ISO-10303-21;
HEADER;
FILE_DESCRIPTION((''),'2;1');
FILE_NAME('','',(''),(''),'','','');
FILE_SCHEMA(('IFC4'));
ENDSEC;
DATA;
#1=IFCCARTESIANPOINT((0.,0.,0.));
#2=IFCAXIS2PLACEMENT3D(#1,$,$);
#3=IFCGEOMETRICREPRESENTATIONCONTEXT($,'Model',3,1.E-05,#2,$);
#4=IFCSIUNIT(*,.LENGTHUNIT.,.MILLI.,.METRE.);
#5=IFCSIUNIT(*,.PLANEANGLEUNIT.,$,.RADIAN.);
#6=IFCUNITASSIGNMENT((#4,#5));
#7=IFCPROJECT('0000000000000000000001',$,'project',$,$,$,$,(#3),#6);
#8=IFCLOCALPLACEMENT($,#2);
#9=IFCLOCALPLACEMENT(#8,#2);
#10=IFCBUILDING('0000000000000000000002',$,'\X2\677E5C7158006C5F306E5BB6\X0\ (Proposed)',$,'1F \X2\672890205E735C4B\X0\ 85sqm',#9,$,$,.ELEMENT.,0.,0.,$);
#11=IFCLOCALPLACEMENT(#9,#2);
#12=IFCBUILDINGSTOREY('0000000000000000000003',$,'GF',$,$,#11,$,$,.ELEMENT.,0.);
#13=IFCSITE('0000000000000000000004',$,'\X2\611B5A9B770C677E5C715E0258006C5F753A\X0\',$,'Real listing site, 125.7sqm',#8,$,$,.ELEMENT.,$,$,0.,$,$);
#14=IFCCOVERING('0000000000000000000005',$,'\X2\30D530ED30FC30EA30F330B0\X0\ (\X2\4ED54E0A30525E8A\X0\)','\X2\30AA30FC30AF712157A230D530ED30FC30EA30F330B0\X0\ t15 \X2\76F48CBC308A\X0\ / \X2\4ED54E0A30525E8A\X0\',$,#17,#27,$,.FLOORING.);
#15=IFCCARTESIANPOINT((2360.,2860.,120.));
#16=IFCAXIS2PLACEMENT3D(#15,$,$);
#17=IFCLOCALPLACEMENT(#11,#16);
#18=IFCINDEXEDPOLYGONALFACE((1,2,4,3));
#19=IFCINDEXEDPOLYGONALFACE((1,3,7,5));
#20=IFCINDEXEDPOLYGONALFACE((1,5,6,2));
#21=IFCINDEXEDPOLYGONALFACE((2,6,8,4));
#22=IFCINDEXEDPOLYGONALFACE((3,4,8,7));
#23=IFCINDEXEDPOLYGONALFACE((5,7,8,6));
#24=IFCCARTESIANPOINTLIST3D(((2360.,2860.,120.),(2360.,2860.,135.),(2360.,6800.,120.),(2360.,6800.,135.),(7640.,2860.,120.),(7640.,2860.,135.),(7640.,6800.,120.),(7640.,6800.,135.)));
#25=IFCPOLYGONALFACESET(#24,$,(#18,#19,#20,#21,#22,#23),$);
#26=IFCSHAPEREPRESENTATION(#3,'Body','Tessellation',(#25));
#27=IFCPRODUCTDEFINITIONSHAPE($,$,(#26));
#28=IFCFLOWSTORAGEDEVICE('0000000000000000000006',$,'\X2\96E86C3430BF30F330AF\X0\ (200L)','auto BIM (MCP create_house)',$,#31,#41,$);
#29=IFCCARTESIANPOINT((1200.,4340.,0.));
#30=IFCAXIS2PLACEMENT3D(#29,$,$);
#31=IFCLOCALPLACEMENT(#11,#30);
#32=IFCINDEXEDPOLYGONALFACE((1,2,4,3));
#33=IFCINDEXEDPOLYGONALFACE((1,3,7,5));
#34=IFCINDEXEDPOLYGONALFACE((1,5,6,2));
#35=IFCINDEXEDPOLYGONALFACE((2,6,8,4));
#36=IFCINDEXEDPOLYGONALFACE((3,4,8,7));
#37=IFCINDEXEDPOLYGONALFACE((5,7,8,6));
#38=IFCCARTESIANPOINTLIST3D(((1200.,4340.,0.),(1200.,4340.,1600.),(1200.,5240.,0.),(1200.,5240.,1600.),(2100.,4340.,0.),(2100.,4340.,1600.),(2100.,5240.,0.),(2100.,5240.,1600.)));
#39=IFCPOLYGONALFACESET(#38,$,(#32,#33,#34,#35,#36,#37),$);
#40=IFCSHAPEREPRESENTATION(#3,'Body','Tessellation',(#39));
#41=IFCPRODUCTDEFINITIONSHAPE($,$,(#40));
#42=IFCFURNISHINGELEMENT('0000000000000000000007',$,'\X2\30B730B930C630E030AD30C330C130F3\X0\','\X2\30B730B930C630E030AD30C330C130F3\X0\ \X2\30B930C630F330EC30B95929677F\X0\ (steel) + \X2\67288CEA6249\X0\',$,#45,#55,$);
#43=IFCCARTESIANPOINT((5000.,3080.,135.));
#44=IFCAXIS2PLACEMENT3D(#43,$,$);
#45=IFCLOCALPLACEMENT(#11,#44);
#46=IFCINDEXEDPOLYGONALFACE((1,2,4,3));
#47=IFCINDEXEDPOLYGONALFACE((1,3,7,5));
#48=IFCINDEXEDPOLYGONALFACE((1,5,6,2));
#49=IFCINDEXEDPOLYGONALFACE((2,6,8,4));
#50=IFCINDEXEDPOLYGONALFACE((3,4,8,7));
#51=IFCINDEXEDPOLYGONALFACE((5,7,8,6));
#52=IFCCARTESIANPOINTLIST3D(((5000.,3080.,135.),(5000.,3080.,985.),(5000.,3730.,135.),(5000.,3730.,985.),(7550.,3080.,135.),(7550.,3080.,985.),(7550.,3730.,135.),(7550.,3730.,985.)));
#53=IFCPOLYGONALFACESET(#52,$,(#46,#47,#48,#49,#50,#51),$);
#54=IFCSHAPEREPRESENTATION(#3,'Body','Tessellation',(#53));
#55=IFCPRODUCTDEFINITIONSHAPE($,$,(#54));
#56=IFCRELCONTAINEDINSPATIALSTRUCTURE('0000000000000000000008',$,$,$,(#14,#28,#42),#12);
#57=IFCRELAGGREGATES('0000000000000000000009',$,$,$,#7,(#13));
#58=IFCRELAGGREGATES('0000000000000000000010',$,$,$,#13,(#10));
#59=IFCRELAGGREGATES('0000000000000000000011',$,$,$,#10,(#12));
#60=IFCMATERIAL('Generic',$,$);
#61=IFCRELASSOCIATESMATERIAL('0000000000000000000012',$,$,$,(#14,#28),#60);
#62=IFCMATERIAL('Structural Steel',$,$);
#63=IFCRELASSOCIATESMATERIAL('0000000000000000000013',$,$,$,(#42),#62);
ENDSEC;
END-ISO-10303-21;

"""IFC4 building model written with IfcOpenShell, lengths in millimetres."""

from ifc_helpers import new_model, si_unit, frame, frame_2d, origin, place, context, project, spatial, rectangle, extrude, material, element, save


model = new_model("IFC4")

# Units and contexts
model_context = context("Model", 3, precision=1e-05, world=origin())
ifc_project = project(units=[si_unit("LENGTHUNIT", "METRE", prefix="MILLI"), si_unit("PLANEANGLEUNIT", "RADIAN")], contexts=[model_context])

# Site, building, storey
site_placement = place(None, origin())
site = spatial("IfcSite", under=ifc_project, at=site_placement, Name="愛媛県松山市堀江町", ObjectType="Real listing site, 125.7sqm", CompositionType="ELEMENT", RefElevation=0.0)
building_placement = place(site_placement, origin())
building = spatial("IfcBuilding", under=site, at=building_placement, Name="松山堀江の家 (Proposed)", ObjectType="1F 木造平屋 85sqm", CompositionType="ELEMENT", ElevationOfRefHeight=0.0, ElevationOfTerrain=0.0)
storey_placement = place(building_placement, origin())
storey = spatial("IfcBuildingStorey", under=building, at=storey_placement, Name="GF", CompositionType="ELEMENT", Elevation=0.0)

# Shared definitions
ifc_material_1 = material(Name="Generic")

# Covering
covering_placement = place(storey_placement, frame((2360.0, 2860.0, 120.0)))
element("IfcCovering", 1, at=covering_placement, inside=storey, material=ifc_material_1, Name="フローリング (仕上げ床)", Description="オーク無垢フローリング t15 直貼り / 仕上げ床", PredefinedType="FLOORING", context=model_context, shape_type="SweptSolid", body=[
    extrude(rectangle(XDim=5280.0, YDim=3940.0, at=frame_2d((2640.0, 1970.0))), frame((2360.0, 2860.0, 120.0)), (0.0, 0.0, 1.0), 15.0),
])

# Flow storage device
flow_storage_device_placement = place(storey_placement, frame((1200.0, 4340.0, 0.0)))
element("IfcFlowStorageDevice", 2, at=flow_storage_device_placement, inside=storey, material=ifc_material_1, Name="雨水タンク (200L)", Description="auto BIM (MCP create_house)", context=model_context, shape_type="SweptSolid", body=[
    extrude(rectangle(XDim=900.0, YDim=900.0, at=frame_2d((450.0, 450.0))), frame((1200.0, 4340.0, 0.0)), (0.0, 0.0, 1.0), 1600.0),
])

# Furnishing element
ifc_material_2 = material(Name="Structural Steel")
furnishing_placement = place(storey_placement, frame((5000.0, 3080.0, 135.0)))
element("IfcFurnishingElement", 3, at=furnishing_placement, inside=storey, material=ifc_material_2, Name="システムキッチン", Description="システムキッチン ステンレス天板 (steel) + 木質扉", context=model_context, shape_type="SweptSolid", body=[
    extrude(rectangle(XDim=2550.0, YDim=650.0, at=frame_2d((1275.0, 325.0))), frame((5000.0, 3080.0, 135.0)), (0.0, 0.0, 1.0), 850.0),
])

save(model, "model.ifc")
